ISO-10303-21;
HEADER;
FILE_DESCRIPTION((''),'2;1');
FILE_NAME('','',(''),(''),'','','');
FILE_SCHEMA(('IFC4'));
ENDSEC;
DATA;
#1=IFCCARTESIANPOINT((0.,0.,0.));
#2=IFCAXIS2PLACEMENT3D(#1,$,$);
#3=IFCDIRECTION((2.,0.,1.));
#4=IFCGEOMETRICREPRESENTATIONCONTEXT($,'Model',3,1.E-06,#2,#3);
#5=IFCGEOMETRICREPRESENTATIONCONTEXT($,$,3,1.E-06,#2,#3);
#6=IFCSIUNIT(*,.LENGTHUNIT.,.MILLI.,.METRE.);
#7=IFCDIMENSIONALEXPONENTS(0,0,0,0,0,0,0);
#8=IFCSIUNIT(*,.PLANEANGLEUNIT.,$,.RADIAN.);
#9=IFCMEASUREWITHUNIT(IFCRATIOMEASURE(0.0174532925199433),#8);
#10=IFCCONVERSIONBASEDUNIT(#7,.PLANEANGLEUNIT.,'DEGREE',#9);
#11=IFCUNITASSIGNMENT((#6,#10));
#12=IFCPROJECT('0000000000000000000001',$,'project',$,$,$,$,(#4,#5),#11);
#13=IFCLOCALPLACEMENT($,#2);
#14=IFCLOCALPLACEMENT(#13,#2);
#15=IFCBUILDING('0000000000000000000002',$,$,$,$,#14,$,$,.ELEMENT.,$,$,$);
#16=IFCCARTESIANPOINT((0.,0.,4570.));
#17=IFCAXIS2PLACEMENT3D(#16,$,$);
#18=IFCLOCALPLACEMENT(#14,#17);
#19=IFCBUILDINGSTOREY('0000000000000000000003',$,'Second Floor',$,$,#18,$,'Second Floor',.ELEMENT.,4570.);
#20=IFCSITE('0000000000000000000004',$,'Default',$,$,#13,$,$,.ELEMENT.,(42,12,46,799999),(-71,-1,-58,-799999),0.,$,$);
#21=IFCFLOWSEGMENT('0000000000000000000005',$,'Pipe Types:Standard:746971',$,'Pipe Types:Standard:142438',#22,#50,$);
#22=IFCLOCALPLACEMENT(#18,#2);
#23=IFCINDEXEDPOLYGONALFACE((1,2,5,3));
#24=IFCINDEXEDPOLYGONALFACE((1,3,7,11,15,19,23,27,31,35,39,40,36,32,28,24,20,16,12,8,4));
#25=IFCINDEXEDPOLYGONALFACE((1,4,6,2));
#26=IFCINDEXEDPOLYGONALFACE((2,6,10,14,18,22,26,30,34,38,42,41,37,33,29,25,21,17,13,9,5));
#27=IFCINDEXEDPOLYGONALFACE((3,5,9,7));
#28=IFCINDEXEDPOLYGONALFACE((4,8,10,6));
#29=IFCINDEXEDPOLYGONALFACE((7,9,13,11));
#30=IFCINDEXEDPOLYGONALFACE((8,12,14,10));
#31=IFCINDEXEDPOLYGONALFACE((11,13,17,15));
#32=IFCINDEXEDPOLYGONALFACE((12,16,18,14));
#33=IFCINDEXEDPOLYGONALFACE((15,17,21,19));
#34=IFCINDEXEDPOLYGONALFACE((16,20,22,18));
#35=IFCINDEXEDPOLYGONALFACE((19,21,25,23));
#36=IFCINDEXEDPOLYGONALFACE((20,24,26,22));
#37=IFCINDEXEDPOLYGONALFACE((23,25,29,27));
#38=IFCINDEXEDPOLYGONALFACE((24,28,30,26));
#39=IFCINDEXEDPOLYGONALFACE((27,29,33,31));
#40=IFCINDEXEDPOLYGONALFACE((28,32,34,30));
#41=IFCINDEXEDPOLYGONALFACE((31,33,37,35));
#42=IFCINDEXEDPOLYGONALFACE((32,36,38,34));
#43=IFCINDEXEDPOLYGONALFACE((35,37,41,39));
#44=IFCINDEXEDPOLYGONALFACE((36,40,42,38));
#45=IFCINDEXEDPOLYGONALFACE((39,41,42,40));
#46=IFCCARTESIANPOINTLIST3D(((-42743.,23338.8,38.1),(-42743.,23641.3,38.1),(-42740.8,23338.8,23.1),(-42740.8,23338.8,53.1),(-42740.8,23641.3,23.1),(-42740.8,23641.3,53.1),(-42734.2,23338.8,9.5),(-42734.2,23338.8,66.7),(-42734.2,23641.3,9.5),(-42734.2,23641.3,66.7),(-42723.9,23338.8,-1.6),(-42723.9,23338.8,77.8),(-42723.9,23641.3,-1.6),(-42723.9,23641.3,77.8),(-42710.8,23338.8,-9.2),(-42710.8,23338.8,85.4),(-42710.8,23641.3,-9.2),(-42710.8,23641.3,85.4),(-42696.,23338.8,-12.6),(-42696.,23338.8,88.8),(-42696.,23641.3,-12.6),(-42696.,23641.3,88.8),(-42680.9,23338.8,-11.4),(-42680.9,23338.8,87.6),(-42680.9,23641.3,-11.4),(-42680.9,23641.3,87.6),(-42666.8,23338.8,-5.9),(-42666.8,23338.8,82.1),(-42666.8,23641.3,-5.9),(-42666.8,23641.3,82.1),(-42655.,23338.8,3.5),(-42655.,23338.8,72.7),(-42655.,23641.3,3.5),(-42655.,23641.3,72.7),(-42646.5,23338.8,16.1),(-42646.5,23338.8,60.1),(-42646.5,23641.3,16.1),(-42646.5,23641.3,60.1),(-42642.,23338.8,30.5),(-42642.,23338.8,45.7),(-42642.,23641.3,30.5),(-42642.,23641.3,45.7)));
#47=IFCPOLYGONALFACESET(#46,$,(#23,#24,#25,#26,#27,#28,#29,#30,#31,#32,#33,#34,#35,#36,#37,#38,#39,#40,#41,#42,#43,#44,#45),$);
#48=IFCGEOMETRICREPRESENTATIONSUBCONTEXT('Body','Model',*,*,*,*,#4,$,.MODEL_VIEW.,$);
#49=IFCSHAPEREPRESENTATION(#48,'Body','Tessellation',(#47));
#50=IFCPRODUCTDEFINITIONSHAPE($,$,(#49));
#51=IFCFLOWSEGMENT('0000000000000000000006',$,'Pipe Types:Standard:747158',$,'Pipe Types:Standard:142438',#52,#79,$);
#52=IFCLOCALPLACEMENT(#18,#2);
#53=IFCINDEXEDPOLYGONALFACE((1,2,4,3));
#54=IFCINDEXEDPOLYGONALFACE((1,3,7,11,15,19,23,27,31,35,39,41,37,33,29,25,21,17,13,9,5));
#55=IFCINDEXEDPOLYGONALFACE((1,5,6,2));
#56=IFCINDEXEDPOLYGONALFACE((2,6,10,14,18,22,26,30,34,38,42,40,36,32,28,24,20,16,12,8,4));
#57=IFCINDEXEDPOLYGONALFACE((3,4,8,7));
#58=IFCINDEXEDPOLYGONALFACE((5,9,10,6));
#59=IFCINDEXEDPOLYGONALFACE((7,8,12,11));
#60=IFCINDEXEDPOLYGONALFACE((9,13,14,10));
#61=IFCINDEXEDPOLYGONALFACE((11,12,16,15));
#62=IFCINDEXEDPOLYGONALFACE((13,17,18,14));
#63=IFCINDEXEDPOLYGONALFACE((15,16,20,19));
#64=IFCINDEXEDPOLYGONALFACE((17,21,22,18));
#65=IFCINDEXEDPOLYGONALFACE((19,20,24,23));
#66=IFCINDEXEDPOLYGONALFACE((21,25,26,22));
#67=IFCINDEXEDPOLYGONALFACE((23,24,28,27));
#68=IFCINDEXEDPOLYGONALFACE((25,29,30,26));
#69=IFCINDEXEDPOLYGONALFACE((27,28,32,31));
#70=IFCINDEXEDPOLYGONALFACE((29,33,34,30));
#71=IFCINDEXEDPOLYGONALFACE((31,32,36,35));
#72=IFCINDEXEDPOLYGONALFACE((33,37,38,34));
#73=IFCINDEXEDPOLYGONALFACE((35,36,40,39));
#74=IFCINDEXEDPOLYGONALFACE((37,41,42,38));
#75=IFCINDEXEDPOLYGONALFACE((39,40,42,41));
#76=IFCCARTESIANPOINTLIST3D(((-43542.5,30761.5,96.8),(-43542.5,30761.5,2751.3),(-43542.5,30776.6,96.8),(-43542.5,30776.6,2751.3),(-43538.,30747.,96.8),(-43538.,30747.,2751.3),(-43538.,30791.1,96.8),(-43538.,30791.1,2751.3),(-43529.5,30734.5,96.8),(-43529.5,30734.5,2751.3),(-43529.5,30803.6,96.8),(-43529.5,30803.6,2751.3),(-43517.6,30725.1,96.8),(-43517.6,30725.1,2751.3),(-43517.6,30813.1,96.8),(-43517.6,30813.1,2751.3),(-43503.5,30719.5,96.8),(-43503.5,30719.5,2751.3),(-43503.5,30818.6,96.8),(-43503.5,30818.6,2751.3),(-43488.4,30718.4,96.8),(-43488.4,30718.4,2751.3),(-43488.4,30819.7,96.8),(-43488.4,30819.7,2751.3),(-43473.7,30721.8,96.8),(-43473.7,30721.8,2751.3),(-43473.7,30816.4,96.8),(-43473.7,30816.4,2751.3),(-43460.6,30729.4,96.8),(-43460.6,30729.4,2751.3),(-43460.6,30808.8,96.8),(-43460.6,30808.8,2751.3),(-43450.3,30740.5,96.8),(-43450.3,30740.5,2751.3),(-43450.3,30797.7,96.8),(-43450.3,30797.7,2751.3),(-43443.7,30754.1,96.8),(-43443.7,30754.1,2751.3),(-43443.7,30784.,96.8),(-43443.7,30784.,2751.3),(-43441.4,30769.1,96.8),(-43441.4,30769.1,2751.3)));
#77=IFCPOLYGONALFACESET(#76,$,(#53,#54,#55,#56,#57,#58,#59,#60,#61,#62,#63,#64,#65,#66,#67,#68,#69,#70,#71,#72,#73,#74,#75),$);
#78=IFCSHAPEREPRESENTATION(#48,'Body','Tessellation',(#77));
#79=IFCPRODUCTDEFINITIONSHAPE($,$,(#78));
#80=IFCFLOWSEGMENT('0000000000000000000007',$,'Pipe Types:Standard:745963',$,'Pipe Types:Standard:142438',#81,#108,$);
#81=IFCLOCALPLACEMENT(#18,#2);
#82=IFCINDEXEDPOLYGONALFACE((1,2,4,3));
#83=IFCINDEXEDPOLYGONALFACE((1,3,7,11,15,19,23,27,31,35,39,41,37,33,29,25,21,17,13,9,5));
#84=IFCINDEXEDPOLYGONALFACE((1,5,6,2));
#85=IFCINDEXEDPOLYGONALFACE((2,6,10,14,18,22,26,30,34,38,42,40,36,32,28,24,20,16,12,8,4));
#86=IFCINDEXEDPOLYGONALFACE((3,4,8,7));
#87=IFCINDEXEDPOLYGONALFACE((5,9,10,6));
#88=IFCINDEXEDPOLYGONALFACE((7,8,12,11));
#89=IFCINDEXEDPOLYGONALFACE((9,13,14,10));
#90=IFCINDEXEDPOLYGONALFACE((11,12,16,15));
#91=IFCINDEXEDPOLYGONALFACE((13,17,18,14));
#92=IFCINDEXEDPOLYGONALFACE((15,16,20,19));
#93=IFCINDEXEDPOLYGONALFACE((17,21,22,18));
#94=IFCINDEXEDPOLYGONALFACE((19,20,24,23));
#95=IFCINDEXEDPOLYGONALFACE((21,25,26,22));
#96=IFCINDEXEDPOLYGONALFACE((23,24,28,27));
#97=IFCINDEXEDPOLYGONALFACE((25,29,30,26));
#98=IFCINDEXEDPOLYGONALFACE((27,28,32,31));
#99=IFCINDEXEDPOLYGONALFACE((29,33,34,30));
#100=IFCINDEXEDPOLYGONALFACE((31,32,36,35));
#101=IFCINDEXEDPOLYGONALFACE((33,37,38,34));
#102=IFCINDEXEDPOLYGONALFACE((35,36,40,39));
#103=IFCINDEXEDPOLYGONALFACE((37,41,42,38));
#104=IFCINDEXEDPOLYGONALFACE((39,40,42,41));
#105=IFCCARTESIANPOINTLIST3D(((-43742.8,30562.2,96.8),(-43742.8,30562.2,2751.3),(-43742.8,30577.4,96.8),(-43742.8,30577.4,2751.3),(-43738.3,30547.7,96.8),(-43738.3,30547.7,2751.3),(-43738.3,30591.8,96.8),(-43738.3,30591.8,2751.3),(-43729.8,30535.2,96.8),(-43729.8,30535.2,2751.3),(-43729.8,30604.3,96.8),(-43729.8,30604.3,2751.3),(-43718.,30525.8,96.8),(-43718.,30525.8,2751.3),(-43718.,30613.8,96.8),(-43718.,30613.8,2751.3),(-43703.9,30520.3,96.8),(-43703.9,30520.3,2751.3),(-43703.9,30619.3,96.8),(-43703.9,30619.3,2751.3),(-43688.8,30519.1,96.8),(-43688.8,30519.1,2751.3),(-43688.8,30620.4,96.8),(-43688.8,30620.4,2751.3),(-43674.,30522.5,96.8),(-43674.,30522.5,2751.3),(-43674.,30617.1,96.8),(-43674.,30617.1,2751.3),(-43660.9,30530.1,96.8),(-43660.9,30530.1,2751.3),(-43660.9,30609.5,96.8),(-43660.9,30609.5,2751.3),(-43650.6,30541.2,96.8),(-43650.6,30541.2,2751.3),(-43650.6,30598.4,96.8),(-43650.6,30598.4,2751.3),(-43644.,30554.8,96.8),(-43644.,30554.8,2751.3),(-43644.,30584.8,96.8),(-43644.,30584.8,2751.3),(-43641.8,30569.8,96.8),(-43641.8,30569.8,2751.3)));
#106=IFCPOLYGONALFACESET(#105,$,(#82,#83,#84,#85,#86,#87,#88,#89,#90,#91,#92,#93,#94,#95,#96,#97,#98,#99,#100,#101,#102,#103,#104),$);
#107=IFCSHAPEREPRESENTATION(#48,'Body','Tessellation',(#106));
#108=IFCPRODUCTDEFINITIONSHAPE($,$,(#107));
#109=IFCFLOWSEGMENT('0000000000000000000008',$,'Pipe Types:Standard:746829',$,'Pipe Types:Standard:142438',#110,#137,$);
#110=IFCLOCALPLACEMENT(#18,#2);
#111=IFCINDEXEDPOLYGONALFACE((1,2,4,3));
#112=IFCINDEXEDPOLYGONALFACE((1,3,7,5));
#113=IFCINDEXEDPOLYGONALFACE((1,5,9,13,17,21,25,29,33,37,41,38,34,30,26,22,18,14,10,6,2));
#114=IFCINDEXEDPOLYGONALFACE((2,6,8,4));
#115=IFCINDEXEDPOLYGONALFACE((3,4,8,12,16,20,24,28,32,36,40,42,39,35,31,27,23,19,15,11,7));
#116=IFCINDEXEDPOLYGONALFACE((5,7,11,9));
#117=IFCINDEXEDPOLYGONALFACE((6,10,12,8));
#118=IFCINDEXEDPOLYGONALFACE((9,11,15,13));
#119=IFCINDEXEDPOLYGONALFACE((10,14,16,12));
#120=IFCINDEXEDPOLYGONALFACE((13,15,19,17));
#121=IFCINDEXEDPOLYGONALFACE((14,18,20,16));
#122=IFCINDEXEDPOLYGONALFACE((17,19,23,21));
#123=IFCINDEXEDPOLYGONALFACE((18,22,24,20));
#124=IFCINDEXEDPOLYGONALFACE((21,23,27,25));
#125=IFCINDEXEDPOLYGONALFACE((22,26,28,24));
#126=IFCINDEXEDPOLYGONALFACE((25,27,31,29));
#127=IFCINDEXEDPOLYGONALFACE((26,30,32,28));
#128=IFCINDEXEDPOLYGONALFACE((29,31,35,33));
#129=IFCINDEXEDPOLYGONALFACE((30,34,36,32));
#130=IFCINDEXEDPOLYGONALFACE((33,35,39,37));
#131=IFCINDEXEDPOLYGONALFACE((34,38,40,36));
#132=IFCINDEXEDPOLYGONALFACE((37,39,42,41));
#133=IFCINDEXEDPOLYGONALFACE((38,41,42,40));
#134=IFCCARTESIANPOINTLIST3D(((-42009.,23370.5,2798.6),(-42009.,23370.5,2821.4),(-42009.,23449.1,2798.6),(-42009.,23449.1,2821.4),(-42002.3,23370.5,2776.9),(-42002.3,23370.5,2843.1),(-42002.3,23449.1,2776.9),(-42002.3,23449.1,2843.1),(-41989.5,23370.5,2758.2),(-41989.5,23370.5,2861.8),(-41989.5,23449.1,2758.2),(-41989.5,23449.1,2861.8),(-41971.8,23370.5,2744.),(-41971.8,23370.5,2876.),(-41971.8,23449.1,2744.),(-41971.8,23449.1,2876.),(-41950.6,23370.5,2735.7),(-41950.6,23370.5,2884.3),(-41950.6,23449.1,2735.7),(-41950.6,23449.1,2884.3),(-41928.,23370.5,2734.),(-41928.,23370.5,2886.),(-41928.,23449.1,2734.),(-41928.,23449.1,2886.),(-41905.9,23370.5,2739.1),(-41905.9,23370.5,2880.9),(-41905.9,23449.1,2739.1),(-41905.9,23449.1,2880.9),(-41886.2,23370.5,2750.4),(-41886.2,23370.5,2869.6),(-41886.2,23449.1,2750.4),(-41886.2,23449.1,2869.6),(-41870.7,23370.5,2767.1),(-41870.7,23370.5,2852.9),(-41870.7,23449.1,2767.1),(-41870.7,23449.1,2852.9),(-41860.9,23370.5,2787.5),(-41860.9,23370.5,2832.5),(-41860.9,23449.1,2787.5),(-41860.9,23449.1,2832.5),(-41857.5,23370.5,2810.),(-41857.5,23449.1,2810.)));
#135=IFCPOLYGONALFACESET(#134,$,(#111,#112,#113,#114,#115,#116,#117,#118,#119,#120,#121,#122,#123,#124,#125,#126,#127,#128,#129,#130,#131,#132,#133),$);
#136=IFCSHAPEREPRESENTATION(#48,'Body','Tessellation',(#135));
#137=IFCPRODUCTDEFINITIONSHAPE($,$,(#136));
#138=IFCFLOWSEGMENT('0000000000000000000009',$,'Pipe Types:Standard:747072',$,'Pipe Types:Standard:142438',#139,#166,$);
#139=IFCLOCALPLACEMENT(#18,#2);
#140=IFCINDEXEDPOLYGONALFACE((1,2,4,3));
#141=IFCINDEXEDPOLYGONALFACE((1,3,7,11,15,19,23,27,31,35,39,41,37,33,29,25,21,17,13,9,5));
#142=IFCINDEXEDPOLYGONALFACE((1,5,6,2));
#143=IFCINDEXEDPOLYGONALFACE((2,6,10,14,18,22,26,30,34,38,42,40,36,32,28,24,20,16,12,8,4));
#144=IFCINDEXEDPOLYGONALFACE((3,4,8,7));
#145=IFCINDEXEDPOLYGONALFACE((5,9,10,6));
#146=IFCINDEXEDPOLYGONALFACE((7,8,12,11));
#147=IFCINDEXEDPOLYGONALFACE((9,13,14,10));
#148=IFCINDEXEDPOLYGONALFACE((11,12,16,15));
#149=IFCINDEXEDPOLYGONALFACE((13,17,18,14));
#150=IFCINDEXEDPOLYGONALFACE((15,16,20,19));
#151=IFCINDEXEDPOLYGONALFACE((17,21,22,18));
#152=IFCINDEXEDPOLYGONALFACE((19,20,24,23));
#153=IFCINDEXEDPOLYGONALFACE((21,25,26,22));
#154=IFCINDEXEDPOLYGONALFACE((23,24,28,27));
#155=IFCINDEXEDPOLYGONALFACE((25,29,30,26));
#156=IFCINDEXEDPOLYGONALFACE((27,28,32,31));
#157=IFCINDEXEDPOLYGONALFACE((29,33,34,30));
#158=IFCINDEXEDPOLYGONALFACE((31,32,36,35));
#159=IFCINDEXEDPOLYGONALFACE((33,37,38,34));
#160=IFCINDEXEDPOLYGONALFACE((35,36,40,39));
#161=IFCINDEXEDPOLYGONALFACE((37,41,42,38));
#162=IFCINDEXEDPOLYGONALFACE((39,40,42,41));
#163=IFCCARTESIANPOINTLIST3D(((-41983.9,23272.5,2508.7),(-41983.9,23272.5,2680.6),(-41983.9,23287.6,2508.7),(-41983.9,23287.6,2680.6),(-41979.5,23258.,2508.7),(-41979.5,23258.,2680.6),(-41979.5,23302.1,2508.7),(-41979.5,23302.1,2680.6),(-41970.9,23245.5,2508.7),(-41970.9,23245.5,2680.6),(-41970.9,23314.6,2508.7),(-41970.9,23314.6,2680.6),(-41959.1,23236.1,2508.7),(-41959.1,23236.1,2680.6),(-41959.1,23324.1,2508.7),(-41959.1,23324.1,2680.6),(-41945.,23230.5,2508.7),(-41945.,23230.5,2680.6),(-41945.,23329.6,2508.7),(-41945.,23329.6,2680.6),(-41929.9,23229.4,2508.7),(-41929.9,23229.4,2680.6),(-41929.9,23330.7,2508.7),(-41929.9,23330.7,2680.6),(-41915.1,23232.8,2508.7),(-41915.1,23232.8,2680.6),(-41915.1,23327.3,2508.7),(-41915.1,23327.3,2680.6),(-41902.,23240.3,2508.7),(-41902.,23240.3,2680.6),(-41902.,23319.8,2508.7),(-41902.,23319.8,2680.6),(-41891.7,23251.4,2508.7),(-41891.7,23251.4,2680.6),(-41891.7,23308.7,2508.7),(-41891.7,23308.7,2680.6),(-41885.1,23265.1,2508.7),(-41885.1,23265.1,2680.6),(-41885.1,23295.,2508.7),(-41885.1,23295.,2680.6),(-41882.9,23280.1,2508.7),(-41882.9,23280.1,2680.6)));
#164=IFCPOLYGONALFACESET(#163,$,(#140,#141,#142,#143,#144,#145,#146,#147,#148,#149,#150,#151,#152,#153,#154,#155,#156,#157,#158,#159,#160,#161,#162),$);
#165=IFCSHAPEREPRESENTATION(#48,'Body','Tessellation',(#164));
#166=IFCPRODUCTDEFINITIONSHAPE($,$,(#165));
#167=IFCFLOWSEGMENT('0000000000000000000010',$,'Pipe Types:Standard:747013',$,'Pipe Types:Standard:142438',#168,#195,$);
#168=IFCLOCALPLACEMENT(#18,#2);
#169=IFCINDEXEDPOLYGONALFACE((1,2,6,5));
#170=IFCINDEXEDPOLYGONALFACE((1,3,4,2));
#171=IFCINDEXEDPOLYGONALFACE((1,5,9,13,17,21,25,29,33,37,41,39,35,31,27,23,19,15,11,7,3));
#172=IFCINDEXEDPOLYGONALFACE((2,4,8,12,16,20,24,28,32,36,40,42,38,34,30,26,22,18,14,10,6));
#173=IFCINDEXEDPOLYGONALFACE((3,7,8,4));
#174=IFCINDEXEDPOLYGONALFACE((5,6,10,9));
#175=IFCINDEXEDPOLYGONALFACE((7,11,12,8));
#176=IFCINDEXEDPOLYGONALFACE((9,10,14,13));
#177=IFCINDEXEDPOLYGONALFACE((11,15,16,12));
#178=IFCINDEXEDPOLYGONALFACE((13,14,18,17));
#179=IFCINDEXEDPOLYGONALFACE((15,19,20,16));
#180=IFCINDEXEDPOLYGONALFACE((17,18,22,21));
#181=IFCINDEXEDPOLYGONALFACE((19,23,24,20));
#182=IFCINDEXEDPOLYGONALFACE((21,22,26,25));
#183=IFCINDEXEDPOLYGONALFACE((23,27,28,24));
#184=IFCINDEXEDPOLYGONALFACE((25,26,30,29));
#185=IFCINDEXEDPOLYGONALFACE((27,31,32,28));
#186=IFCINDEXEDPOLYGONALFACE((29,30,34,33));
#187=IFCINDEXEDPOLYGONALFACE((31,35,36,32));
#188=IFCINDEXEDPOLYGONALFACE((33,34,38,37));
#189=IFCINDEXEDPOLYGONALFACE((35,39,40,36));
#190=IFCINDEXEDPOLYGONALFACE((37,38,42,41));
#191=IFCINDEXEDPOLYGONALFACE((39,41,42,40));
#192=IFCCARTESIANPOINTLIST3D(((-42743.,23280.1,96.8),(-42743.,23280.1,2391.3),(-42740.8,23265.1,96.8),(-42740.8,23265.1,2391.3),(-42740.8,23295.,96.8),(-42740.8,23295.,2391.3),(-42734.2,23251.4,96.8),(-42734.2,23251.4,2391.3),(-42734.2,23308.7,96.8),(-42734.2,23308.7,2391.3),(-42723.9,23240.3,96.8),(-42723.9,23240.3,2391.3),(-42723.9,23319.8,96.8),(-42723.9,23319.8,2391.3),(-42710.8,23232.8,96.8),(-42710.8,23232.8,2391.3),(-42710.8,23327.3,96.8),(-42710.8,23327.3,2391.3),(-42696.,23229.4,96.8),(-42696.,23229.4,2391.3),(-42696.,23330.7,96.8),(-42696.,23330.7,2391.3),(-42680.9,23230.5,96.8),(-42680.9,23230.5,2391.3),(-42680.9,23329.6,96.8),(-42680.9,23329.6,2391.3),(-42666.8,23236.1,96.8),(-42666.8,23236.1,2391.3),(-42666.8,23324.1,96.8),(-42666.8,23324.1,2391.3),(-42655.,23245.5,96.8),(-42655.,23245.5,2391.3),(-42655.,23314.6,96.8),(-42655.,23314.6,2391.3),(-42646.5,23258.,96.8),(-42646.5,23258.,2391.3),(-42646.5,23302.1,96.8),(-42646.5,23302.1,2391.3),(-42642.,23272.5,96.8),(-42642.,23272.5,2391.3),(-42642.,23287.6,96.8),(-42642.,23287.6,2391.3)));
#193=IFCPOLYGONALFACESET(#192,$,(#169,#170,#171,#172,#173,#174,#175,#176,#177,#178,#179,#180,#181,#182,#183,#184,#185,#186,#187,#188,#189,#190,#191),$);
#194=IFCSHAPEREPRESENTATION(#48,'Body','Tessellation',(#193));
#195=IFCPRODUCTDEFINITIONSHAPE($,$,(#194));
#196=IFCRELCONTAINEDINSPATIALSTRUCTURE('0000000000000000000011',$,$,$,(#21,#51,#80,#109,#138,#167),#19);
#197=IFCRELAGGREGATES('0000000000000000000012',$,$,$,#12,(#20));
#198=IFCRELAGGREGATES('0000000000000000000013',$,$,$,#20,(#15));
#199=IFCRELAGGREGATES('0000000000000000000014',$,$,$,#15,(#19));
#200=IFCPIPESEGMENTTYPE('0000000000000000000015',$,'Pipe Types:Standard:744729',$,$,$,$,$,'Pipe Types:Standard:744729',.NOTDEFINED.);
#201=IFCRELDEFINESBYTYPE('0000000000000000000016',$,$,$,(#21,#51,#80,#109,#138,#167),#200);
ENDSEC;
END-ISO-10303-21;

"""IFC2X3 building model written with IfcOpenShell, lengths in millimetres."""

from ifc_helpers import new_model, entity, si_unit, converted_unit, direction, frame, frame_2d, origin, origin_2d_with_axis, place, context, subcontext, project, spatial, circle, extrude, type_object, element, save


model = new_model("IFC2X3")

# Units and contexts
model_context = context("Model", 3, precision=1e-06, world=origin(), true_north=direction((2.0, 0.0, 1.0)))
context_of_model = context(None, 3, precision=1e-06, world=origin(), true_north=direction((2.0, 0.0, 1.0)))
body_context = subcontext(model_context, "Body", "Model", "MODEL_VIEW")
ifc_project = project(units=[si_unit("LENGTHUNIT", "METRE", prefix="MILLI"), converted_unit("PLANEANGLEUNIT", "DEGREE", entity("IfcRatioMeasure", 0.0174532925199433), si_unit("PLANEANGLEUNIT", "RADIAN"), dimensions=[0, 0, 0, 0, 0, 0, 0])], contexts=[model_context, context_of_model])

# Site, building, storey
site_placement = place(None, origin())
site = spatial("IfcSite", under=ifc_project, at=site_placement, Name="Default", CompositionType="ELEMENT", RefLatitude=(42, 12, 46, 799999), RefLongitude=(-71, -1, -58, -799999), RefElevation=0.0)
building_placement = place(site_placement, origin())
building = spatial("IfcBuilding", under=site, at=building_placement, CompositionType="ELEMENT")
storey_placement = place(building_placement, frame((0.0, 0.0, 4570.0)))
storey = spatial("IfcBuildingStorey", under=building, at=storey_placement, Name="Second Floor", LongName="Second Floor", CompositionType="ELEMENT", Elevation=4570.0)

# Flow segments
pipe_segment_type = type_object("IfcPipeSegmentType", Name="Pipe Types:Standard:744729", ElementType="Pipe Types:Standard:744729", PredefinedType="NOTDEFINED")
flow_segment_1_placement = place(storey_placement, origin())
element("IfcFlowSegment", 1, at=flow_segment_1_placement, inside=storey, type_object=pipe_segment_type, Name="Pipe Types:Standard:746971", ObjectType="Pipe Types:Standard:142438", context=body_context, shape_type="SweptSolid", body=[
    extrude(circle(Radius=50.8, at=origin_2d_with_axis()), frame((-42692.2, 23338.8, 38.1), z_axis=(0.0, 1.0, 0.0), x_axis=(-1.0, 0.0, 0.0)), (0.0, 0.0, 1.0), 302.5),
])
flow_segment_2_placement = place(storey_placement, origin())
element("IfcFlowSegment", 2, at=flow_segment_2_placement, inside=storey, type_object=pipe_segment_type, Name="Pipe Types:Standard:747158", ObjectType="Pipe Types:Standard:142438", context=body_context, shape_type="SweptSolid", body=[
    extrude(circle(Radius=50.8, at=origin_2d_with_axis()), frame((-43492.2, 30769.1, 96.8)), (0.0, 0.0, 1.0), 2654.4),
])
flow_segment_3_placement = place(storey_placement, origin())
element("IfcFlowSegment", 3, at=flow_segment_3_placement, inside=storey, type_object=pipe_segment_type, Name="Pipe Types:Standard:745963", ObjectType="Pipe Types:Standard:142438", context=body_context, shape_type="SweptSolid", body=[
    extrude(circle(Radius=50.8, at=frame_2d((0.0, 0.0), x_axis=(1.0, 0.0))), frame((-43692.6, 30569.8, 96.8)), (0.0, 0.0, 1.0), 2654.4),
])
flow_segment_4_placement = place(storey_placement, origin())
element("IfcFlowSegment", 4, at=flow_segment_4_placement, inside=storey, type_object=pipe_segment_type, Name="Pipe Types:Standard:746829", ObjectType="Pipe Types:Standard:142438", context=body_context, shape_type="SweptSolid", body=[
    extrude(circle(Radius=76.2, at=origin_2d_with_axis()), frame((-41933.7, 23370.5, 2810.0), z_axis=(0.0, 1.0, 0.0), x_axis=(1.0, 0.0, 0.0)), (0.0, 0.0, 1.0), 78.5),
])
flow_segment_5_placement = place(storey_placement, origin())
element("IfcFlowSegment", 5, at=flow_segment_5_placement, inside=storey, type_object=pipe_segment_type, Name="Pipe Types:Standard:747072", ObjectType="Pipe Types:Standard:142438", context=body_context, shape_type="SweptSolid", body=[
    extrude(circle(Radius=50.8, at=origin_2d_with_axis()), frame((-41933.7, 23280.1, 2508.7)), (0.0, 0.0, 1.0), 171.9),
])
flow_segment_6_placement = place(storey_placement, origin())
element("IfcFlowSegment", 6, at=flow_segment_6_placement, inside=storey, type_object=pipe_segment_type, Name="Pipe Types:Standard:747013", ObjectType="Pipe Types:Standard:142438", context=body_context, shape_type="SweptSolid", body=[
    extrude(circle(Radius=50.8, at=origin_2d_with_axis()), frame((-42692.2, 23280.1, 96.8), z_axis=(0.0, 0.0, 1.0), x_axis=(-1.0, 0.0, 0.0)), (0.0, 0.0, 1.0), 2294.4),
])

save(model, "model.ifc")
